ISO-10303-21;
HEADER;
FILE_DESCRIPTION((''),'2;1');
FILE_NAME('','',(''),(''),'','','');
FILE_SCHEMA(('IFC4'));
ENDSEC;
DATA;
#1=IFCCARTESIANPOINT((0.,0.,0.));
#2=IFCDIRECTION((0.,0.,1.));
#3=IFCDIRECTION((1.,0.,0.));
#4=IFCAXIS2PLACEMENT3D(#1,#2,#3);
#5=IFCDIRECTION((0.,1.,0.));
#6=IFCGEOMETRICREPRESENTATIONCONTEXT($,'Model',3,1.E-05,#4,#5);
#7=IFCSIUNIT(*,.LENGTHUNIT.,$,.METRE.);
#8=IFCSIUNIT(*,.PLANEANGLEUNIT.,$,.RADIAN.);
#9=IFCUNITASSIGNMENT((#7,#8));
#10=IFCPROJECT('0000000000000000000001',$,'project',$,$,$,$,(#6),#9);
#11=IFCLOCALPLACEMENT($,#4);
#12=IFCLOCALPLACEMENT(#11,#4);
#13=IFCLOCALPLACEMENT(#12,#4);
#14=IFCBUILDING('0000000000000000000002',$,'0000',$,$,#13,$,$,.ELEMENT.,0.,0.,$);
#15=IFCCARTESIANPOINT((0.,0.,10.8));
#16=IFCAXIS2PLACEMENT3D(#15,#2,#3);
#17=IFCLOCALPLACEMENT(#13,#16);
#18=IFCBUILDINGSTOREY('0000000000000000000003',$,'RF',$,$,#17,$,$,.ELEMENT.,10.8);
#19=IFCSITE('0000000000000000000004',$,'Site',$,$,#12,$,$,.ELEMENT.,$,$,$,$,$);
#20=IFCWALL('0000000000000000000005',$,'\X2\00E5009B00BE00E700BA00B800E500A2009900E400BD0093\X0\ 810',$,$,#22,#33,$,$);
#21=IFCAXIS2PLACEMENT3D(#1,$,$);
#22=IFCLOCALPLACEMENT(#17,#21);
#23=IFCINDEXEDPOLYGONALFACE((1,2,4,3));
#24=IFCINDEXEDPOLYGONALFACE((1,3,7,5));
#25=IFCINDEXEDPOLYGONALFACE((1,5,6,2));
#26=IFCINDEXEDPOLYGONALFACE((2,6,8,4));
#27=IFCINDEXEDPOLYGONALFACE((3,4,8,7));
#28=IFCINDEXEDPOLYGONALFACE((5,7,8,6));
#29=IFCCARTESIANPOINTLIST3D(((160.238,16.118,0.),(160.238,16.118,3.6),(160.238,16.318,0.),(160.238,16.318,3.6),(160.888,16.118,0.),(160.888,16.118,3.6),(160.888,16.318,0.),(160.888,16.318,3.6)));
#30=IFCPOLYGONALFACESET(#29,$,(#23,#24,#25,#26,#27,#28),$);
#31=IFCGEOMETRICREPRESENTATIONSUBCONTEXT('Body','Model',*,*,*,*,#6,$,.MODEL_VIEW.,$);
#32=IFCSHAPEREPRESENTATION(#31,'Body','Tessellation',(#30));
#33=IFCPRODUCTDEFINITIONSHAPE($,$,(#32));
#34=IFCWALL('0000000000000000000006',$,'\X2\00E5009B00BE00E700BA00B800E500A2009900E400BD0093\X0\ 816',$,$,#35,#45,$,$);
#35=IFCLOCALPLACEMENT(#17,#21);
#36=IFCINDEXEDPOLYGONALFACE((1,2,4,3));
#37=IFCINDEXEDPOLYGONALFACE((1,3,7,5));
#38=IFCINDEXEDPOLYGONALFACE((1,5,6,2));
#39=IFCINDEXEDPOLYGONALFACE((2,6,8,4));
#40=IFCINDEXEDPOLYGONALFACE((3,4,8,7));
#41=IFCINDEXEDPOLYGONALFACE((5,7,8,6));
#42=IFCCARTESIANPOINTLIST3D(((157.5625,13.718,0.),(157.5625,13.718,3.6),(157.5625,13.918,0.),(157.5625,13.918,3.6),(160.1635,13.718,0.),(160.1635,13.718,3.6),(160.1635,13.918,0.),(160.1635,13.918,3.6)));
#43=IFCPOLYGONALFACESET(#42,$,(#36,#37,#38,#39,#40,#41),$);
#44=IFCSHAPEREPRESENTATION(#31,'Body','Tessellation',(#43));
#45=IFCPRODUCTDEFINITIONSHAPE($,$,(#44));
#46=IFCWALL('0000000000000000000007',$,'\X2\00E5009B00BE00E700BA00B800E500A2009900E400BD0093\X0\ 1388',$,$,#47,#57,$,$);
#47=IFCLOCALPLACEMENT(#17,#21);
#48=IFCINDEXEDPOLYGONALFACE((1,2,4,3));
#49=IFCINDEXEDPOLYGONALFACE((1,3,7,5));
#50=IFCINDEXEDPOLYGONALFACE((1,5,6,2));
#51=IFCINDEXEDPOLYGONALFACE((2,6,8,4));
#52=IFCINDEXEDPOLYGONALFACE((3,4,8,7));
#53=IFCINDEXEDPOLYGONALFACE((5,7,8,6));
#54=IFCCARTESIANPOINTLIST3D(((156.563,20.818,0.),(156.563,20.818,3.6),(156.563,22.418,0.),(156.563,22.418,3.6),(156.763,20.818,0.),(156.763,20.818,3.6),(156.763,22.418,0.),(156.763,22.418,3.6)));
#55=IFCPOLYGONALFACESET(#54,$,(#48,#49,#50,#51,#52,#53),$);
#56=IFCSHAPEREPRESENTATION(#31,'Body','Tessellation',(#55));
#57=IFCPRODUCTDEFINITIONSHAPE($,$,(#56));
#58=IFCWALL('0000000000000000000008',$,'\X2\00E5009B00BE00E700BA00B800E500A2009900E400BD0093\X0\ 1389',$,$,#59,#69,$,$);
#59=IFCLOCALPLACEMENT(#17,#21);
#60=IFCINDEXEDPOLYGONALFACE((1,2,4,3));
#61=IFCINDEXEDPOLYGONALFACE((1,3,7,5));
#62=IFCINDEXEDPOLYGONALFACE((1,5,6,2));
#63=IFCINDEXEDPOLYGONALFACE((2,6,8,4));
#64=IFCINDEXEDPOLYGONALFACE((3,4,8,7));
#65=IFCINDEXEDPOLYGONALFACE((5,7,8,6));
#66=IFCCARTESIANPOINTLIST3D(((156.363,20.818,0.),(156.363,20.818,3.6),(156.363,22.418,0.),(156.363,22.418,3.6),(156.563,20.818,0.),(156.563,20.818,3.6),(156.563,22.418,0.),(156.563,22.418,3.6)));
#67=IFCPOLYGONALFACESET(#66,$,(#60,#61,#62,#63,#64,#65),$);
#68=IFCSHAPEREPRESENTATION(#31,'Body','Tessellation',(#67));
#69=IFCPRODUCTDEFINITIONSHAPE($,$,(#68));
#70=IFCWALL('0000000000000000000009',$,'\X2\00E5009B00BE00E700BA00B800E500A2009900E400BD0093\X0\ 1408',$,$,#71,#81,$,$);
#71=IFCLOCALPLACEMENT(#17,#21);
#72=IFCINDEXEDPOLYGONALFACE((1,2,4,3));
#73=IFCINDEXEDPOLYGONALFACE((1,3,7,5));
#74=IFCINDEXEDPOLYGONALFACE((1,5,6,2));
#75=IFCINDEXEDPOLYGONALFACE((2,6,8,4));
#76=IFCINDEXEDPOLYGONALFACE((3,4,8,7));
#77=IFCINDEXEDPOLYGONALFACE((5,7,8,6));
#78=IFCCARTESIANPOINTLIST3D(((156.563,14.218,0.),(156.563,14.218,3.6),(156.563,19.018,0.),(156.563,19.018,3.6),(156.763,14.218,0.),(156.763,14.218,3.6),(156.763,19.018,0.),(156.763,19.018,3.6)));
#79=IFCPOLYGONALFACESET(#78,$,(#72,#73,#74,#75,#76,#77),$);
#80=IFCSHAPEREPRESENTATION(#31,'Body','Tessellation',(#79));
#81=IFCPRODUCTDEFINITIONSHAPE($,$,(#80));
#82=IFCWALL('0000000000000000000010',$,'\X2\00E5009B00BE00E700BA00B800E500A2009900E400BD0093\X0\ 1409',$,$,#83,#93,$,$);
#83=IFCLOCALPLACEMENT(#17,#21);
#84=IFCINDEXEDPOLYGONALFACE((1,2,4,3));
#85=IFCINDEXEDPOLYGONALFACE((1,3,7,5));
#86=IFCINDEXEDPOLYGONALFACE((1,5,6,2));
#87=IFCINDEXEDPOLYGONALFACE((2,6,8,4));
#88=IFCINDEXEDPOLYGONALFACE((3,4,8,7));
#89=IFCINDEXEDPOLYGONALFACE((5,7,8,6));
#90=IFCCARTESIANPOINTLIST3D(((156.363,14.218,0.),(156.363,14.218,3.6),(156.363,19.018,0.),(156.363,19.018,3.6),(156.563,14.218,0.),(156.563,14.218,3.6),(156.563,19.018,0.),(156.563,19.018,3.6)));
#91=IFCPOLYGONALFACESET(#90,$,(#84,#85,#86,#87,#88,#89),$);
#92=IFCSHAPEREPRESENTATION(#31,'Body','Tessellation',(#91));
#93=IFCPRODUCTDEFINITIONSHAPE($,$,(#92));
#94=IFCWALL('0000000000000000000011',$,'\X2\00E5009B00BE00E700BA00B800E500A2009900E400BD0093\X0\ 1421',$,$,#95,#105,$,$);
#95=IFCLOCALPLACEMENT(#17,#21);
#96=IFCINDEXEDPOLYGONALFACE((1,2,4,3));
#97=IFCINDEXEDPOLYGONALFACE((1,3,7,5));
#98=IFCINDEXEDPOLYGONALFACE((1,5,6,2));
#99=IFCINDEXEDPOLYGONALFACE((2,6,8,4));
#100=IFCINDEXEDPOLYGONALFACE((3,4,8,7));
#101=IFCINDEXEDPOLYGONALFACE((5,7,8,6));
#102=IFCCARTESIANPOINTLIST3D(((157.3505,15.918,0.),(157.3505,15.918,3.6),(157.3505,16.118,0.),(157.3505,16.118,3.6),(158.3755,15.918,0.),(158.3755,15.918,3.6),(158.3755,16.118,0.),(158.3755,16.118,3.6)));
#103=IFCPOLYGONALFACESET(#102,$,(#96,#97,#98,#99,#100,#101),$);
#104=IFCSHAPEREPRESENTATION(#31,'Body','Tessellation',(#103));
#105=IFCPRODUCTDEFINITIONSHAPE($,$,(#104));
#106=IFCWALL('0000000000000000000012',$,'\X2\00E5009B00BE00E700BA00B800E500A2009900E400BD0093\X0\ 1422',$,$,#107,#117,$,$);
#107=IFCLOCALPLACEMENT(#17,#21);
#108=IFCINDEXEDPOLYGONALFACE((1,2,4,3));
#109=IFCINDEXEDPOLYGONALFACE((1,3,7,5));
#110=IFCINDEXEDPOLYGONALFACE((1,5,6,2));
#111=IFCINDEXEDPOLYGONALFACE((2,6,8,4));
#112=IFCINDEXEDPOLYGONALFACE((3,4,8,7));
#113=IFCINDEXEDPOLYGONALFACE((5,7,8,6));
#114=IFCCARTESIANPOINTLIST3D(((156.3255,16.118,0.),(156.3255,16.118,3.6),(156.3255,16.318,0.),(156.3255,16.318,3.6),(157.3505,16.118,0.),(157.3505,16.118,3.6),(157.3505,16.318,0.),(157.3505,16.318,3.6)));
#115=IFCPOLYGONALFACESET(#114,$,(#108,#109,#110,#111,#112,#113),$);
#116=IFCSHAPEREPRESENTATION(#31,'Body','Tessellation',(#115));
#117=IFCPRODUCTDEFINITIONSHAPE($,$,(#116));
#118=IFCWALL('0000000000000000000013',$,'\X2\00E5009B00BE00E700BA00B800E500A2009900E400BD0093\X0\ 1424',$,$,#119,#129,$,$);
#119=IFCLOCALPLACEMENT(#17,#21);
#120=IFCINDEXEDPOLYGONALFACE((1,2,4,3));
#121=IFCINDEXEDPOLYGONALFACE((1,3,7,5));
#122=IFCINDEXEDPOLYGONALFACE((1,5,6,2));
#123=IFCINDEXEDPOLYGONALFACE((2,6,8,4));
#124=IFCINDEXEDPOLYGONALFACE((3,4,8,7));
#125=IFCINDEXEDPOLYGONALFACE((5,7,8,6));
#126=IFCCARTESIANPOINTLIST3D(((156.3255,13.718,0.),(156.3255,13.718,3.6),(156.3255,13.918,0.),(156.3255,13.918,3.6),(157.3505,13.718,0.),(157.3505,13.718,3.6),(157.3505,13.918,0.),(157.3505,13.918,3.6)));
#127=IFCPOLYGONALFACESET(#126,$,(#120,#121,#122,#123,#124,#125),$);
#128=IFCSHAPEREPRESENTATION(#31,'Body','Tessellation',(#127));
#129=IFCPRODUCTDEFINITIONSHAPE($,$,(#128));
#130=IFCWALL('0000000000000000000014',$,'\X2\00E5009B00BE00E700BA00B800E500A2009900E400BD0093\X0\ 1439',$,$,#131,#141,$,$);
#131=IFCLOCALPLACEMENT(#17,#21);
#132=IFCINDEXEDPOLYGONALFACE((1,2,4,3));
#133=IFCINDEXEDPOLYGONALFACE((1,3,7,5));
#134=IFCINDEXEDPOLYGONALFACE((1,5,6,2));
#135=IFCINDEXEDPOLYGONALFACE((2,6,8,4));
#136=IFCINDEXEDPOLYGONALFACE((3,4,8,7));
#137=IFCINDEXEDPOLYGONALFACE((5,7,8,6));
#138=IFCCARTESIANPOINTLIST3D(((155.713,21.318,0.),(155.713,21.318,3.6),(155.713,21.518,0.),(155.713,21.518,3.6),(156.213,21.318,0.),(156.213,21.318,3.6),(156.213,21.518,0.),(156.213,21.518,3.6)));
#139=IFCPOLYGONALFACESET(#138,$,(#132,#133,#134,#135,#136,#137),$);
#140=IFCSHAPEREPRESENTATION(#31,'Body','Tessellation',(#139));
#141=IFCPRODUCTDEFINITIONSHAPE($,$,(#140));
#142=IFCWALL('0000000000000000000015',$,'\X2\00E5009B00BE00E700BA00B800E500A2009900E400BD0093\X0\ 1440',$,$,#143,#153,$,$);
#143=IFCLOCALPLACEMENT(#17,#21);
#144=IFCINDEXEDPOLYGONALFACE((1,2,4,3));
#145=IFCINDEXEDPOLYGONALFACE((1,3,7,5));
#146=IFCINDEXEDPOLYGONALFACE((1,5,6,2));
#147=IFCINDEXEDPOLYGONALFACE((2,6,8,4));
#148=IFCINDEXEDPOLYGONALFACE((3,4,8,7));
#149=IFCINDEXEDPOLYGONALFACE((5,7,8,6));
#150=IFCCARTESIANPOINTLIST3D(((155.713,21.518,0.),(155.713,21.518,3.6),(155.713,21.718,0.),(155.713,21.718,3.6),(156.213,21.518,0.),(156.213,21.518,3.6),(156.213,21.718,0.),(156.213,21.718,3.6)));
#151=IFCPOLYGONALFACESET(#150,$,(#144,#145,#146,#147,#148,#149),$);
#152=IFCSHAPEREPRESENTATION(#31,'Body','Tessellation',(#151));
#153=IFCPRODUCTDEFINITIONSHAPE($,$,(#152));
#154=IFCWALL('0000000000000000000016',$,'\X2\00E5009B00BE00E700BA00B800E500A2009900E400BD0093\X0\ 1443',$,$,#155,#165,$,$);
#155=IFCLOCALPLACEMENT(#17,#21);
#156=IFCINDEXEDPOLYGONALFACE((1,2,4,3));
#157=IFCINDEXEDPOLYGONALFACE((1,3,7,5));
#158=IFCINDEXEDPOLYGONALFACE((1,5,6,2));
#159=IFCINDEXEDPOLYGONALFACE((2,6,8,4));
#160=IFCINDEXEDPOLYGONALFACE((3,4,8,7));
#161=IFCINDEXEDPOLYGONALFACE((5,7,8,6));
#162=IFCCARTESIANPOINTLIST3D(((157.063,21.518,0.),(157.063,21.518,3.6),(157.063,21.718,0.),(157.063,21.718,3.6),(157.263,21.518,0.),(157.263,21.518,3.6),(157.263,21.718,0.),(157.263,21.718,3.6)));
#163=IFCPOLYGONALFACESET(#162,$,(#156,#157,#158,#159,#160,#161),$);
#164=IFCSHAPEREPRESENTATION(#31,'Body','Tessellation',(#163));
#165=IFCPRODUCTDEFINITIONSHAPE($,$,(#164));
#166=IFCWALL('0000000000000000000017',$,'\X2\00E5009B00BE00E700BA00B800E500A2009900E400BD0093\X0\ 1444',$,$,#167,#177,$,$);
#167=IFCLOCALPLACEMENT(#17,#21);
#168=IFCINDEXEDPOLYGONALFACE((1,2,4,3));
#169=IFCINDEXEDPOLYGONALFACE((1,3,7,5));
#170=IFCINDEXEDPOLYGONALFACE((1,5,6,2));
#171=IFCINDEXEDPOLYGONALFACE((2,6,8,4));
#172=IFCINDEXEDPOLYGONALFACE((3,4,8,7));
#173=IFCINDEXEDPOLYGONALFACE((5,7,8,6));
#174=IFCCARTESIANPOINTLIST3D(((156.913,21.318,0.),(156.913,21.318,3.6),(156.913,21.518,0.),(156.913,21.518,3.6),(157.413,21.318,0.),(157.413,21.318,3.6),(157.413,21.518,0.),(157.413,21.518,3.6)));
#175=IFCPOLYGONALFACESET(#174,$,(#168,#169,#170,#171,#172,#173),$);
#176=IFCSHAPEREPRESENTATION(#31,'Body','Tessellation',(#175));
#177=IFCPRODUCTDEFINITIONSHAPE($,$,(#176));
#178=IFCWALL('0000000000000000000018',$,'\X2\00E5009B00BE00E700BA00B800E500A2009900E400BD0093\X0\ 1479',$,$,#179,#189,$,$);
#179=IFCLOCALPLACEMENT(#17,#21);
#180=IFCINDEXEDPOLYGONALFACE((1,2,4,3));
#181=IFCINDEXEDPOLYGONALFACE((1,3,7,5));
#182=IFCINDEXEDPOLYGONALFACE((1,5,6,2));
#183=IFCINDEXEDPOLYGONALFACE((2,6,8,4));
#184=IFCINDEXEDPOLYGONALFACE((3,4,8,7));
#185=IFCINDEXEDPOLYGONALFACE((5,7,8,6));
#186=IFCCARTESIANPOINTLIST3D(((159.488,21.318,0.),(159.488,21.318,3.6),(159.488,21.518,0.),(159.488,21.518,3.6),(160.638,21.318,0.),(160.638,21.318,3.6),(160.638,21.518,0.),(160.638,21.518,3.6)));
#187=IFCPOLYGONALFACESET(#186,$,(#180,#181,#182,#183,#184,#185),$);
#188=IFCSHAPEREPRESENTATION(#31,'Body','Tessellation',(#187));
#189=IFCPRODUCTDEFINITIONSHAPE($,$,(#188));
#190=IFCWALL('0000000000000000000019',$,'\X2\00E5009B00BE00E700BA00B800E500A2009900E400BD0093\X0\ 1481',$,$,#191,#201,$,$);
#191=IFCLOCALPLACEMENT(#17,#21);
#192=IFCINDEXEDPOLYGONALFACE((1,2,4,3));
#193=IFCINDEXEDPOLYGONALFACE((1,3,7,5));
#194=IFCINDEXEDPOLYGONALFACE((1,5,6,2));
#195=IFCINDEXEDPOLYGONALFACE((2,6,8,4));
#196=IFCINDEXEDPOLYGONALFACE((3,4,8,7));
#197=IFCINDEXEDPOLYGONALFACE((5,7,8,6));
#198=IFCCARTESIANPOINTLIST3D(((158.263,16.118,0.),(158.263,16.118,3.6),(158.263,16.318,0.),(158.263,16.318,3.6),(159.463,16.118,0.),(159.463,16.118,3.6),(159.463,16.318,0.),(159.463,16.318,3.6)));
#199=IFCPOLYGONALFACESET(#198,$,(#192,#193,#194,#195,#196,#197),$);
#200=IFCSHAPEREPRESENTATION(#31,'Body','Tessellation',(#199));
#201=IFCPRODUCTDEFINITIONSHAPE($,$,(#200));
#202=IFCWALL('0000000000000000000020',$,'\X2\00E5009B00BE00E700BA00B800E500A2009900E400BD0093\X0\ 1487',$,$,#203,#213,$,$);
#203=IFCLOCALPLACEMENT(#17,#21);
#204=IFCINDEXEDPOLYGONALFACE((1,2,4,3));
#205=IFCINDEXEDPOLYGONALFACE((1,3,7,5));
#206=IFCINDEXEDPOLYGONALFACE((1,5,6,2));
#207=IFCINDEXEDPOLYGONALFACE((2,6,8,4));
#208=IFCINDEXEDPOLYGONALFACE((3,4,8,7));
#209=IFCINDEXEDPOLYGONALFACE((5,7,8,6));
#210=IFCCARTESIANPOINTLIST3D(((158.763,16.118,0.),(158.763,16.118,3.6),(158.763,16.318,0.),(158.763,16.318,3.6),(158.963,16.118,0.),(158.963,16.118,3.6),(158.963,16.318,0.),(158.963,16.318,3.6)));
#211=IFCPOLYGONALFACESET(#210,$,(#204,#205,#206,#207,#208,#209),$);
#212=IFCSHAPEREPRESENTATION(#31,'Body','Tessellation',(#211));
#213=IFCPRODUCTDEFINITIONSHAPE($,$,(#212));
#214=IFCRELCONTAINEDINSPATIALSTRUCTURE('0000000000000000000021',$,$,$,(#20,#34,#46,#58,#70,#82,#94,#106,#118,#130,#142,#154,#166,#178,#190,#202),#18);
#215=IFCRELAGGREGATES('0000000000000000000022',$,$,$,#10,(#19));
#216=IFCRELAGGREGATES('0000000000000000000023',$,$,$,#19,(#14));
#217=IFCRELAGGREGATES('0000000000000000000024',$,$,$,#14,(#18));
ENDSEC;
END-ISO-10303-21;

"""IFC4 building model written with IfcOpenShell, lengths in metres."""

from ifc_helpers import new_model, si_unit, direction, frame, frame_2d, origin_with_axes, place, context, subcontext, project, spatial, rectangle, extrude, element, save


model = new_model("IFC4")

# Units and contexts
model_context = context("Model", 3, precision=1e-05, world=origin_with_axes(), true_north=direction((0.0, 1.0, 0.0)))
body_context = subcontext(model_context, "Body", "Model", "MODEL_VIEW")
ifc_project = project(units=[si_unit("LENGTHUNIT", "METRE"), si_unit("PLANEANGLEUNIT", "RADIAN")], contexts=[model_context])

# Site, building, storey
placement = place(None, origin_with_axes())
site_placement = place(placement, origin_with_axes())
site = spatial("IfcSite", under=ifc_project, at=site_placement, Name="Site", CompositionType="ELEMENT")
building_placement = place(site_placement, origin_with_axes())
building = spatial("IfcBuilding", under=site, at=building_placement, Name="0000", CompositionType="ELEMENT", ElevationOfRefHeight=0.0, ElevationOfTerrain=0.0)
storey_placement = place(building_placement, frame((0.0, 0.0, 10.8), z_axis=(0.0, 0.0, 1.0), x_axis=(1.0, 0.0, 0.0)))
storey = spatial("IfcBuildingStorey", under=building, at=storey_placement, Name="RF", CompositionType="ELEMENT", Elevation=10.8)

# Walls
wall_1_placement = place(storey_placement, frame((160.563, 16.218, 0.0), z_axis=(0.0, 0.0, 1.0), x_axis=(1.0, 0.0, 0.0)))
element("IfcWall", 1, at=wall_1_placement, inside=storey, Name="å\u009b¾çº¸å¢\u0099ä½\u0093 810", context=body_context, shape_type="SweptSolid", body=[
    extrude(rectangle(XDim=0.65, YDim=0.2, at=frame_2d((0.0, 0.0), x_axis=(1.0, 0.0, 0.0))), frame((0.0, 0.0, 0.0), z_axis=(0.0, 0.0, 1.0)), (0.0, 0.0, 1.0), 3.6),
])
wall_2_placement = place(storey_placement, frame((158.863, 13.818, 0.0), z_axis=(0.0, 0.0, 1.0), x_axis=(1.0, 0.0, 0.0)))
element("IfcWall", 2, at=wall_2_placement, inside=storey, Name="å\u009b¾çº¸å¢\u0099ä½\u0093 816", context=body_context, shape_type="SweptSolid", body=[
    extrude(rectangle(XDim=2.601, YDim=0.2, at=frame_2d((0.0, 0.0), x_axis=(1.0, 0.0, 0.0))), frame((0.0, 0.0, 0.0), z_axis=(0.0, 0.0, 1.0)), (0.0, 0.0, 1.0), 3.6),
])
for number, where, z_axis, x_axis, name in (
    (3, (156.663, 21.618, 0.0), (0.0, 0.0, 1.0), (0.0, 1.0, 0.0), "å\u009b¾çº¸å¢\u0099ä½\u0093 1388"),
    (4, (156.463, 21.618, 0.0), (0.0, 0.0, 1.0), (0.0, 1.0, 0.0), "å\u009b¾çº¸å¢\u0099ä½\u0093 1389"),
):
    element("IfcWall", number, at=place(storey_placement, frame(where, z_axis=z_axis, x_axis=x_axis)), inside=storey, Name=name, context=body_context, shape_type="SweptSolid", body=[
        extrude(rectangle(XDim=1.6, YDim=0.2, at=frame_2d((0.0, 0.0), x_axis=(1.0, 0.0, 0.0))), frame((0.0, 0.0, 0.0), z_axis=(0.0, 0.0, 1.0)), (0.0, 0.0, 1.0), 3.6),
    ])
for number, where, z_axis, x_axis, name in (
    (5, (156.663, 16.618, 0.0), (0.0, 0.0, 1.0), (0.0, 1.0, 0.0), "å\u009b¾çº¸å¢\u0099ä½\u0093 1408"),
    (6, (156.463, 16.618, 0.0), (0.0, 0.0, 1.0), (0.0, 1.0, 0.0), "å\u009b¾çº¸å¢\u0099ä½\u0093 1409"),
):
    element("IfcWall", number, at=place(storey_placement, frame(where, z_axis=z_axis, x_axis=x_axis)), inside=storey, Name=name, context=body_context, shape_type="SweptSolid", body=[
        extrude(rectangle(XDim=4.8, YDim=0.2, at=frame_2d((0.0, 0.0), x_axis=(1.0, 0.0, 0.0))), frame((0.0, 0.0, 0.0), z_axis=(0.0, 0.0, 1.0)), (0.0, 0.0, 1.0), 3.6),
    ])
for number, where, z_axis, x_axis, name in (
    (7, (157.863, 16.018, 0.0), (0.0, 0.0, 1.0), (-1.0, 0.0, 0.0), "å\u009b¾çº¸å¢\u0099ä½\u0093 1421"),
    (8, (156.838, 16.218, 0.0), (0.0, 0.0, 1.0), (1.0, 0.0, 0.0), "å\u009b¾çº¸å¢\u0099ä½\u0093 1422"),
    (9, (156.838, 13.818, 0.0), (0.0, 0.0, 1.0), (1.0, 0.0, 0.0), "å\u009b¾çº¸å¢\u0099ä½\u0093 1424"),
):
    element("IfcWall", number, at=place(storey_placement, frame(where, z_axis=z_axis, x_axis=x_axis)), inside=storey, Name=name, context=body_context, shape_type="SweptSolid", body=[
        extrude(rectangle(XDim=1.025, YDim=0.2, at=frame_2d((0.0, 0.0), x_axis=(1.0, 0.0, 0.0))), frame((0.0, 0.0, 0.0), z_axis=(0.0, 0.0, 1.0)), (0.0, 0.0, 1.0), 3.6),
    ])
for number, where, z_axis, x_axis, name in (
    (10, (155.963, 21.418, 0.0), (0.0, 0.0, 1.0), (1.0, 0.0, 0.0), "å\u009b¾çº¸å¢\u0099ä½\u0093 1439"),
    (11, (155.963, 21.618, 0.0), (0.0, 0.0, 1.0), (1.0, 0.0, 0.0), "å\u009b¾çº¸å¢\u0099ä½\u0093 1440"),
):
    element("IfcWall", number, at=place(storey_placement, frame(where, z_axis=z_axis, x_axis=x_axis)), inside=storey, Name=name, context=body_context, shape_type="SweptSolid", body=[
        extrude(rectangle(XDim=0.5, YDim=0.2, at=frame_2d((0.0, 0.0), x_axis=(1.0, 0.0, 0.0))), frame((0.0, 0.0, 0.0), z_axis=(0.0, 0.0, 1.0)), (0.0, 0.0, 1.0), 3.6),
    ])
wall_3_placement = place(storey_placement, frame((157.163, 21.618, 0.0), z_axis=(0.0, 0.0, 1.0), x_axis=(0.0, -1.0, 0.0)))
element("IfcWall", 12, at=wall_3_placement, inside=storey, Name="å\u009b¾çº¸å¢\u0099ä½\u0093 1443", context=body_context, shape_type="SweptSolid", body=[
    extrude(rectangle(XDim=0.2, YDim=0.2, at=frame_2d((0.0, 0.0), x_axis=(1.0, 0.0, 0.0))), frame((0.0, 0.0, 0.0), z_axis=(0.0, 0.0, 1.0)), (0.0, 0.0, 1.0), 3.6),
])
wall_4_placement = place(storey_placement, frame((157.163, 21.418, 0.0), z_axis=(0.0, 0.0, 1.0), x_axis=(-1.0, 0.0, 0.0)))
element("IfcWall", 13, at=wall_4_placement, inside=storey, Name="å\u009b¾çº¸å¢\u0099ä½\u0093 1444", context=body_context, shape_type="SweptSolid", body=[
    extrude(rectangle(XDim=0.5, YDim=0.2, at=frame_2d((0.0, 0.0), x_axis=(1.0, 0.0, 0.0))), frame((0.0, 0.0, 0.0), z_axis=(0.0, 0.0, 1.0)), (0.0, 0.0, 1.0), 3.6),
])
wall_5_placement = place(storey_placement, frame((160.063, 21.418, 0.0), z_axis=(0.0, 0.0, 1.0), x_axis=(-1.0, 0.0, 0.0)))
element("IfcWall", 14, at=wall_5_placement, inside=storey, Name="å\u009b¾çº¸å¢\u0099ä½\u0093 1479", context=body_context, shape_type="SweptSolid", body=[
    extrude(rectangle(XDim=1.15, YDim=0.2, at=frame_2d((0.0, 0.0), x_axis=(1.0, 0.0, 0.0))), frame((0.0, 0.0, 0.0), z_axis=(0.0, 0.0, 1.0)), (0.0, 0.0, 1.0), 3.6),
])
wall_6_placement = place(storey_placement, frame((158.863, 16.218, 0.0), z_axis=(0.0, 0.0, 1.0), x_axis=(1.0, 0.0, 0.0)))
element("IfcWall", 15, at=wall_6_placement, inside=storey, Name="å\u009b¾çº¸å¢\u0099ä½\u0093 1481", context=body_context, shape_type="SweptSolid", body=[
    extrude(rectangle(XDim=1.2, YDim=0.2, at=frame_2d((0.0, 0.0), x_axis=(1.0, 0.0, 0.0))), frame((0.0, 0.0, 0.0), z_axis=(0.0, 0.0, 1.0)), (0.0, 0.0, 1.0), 3.6),
])
for number, where, z_axis, x_axis, name in (
    (16, (158.863, 16.218, 0.0), (0.0, 0.0, 1.0), (0.0, -1.0, 0.0), "å\u009b¾çº¸å¢\u0099ä½\u0093 1487"),
):
    element("IfcWall", number, at=place(storey_placement, frame(where, z_axis=z_axis, x_axis=x_axis)), inside=storey, Name=name, context=body_context, shape_type="SweptSolid", body=[
        extrude(rectangle(XDim=0.2, YDim=0.2, at=frame_2d((0.0, 0.0), x_axis=(1.0, 0.0, 0.0))), frame((0.0, 0.0, 0.0), z_axis=(0.0, 0.0, 1.0)), (0.0, 0.0, 1.0), 3.6),
    ])

save(model, "model.ifc")
